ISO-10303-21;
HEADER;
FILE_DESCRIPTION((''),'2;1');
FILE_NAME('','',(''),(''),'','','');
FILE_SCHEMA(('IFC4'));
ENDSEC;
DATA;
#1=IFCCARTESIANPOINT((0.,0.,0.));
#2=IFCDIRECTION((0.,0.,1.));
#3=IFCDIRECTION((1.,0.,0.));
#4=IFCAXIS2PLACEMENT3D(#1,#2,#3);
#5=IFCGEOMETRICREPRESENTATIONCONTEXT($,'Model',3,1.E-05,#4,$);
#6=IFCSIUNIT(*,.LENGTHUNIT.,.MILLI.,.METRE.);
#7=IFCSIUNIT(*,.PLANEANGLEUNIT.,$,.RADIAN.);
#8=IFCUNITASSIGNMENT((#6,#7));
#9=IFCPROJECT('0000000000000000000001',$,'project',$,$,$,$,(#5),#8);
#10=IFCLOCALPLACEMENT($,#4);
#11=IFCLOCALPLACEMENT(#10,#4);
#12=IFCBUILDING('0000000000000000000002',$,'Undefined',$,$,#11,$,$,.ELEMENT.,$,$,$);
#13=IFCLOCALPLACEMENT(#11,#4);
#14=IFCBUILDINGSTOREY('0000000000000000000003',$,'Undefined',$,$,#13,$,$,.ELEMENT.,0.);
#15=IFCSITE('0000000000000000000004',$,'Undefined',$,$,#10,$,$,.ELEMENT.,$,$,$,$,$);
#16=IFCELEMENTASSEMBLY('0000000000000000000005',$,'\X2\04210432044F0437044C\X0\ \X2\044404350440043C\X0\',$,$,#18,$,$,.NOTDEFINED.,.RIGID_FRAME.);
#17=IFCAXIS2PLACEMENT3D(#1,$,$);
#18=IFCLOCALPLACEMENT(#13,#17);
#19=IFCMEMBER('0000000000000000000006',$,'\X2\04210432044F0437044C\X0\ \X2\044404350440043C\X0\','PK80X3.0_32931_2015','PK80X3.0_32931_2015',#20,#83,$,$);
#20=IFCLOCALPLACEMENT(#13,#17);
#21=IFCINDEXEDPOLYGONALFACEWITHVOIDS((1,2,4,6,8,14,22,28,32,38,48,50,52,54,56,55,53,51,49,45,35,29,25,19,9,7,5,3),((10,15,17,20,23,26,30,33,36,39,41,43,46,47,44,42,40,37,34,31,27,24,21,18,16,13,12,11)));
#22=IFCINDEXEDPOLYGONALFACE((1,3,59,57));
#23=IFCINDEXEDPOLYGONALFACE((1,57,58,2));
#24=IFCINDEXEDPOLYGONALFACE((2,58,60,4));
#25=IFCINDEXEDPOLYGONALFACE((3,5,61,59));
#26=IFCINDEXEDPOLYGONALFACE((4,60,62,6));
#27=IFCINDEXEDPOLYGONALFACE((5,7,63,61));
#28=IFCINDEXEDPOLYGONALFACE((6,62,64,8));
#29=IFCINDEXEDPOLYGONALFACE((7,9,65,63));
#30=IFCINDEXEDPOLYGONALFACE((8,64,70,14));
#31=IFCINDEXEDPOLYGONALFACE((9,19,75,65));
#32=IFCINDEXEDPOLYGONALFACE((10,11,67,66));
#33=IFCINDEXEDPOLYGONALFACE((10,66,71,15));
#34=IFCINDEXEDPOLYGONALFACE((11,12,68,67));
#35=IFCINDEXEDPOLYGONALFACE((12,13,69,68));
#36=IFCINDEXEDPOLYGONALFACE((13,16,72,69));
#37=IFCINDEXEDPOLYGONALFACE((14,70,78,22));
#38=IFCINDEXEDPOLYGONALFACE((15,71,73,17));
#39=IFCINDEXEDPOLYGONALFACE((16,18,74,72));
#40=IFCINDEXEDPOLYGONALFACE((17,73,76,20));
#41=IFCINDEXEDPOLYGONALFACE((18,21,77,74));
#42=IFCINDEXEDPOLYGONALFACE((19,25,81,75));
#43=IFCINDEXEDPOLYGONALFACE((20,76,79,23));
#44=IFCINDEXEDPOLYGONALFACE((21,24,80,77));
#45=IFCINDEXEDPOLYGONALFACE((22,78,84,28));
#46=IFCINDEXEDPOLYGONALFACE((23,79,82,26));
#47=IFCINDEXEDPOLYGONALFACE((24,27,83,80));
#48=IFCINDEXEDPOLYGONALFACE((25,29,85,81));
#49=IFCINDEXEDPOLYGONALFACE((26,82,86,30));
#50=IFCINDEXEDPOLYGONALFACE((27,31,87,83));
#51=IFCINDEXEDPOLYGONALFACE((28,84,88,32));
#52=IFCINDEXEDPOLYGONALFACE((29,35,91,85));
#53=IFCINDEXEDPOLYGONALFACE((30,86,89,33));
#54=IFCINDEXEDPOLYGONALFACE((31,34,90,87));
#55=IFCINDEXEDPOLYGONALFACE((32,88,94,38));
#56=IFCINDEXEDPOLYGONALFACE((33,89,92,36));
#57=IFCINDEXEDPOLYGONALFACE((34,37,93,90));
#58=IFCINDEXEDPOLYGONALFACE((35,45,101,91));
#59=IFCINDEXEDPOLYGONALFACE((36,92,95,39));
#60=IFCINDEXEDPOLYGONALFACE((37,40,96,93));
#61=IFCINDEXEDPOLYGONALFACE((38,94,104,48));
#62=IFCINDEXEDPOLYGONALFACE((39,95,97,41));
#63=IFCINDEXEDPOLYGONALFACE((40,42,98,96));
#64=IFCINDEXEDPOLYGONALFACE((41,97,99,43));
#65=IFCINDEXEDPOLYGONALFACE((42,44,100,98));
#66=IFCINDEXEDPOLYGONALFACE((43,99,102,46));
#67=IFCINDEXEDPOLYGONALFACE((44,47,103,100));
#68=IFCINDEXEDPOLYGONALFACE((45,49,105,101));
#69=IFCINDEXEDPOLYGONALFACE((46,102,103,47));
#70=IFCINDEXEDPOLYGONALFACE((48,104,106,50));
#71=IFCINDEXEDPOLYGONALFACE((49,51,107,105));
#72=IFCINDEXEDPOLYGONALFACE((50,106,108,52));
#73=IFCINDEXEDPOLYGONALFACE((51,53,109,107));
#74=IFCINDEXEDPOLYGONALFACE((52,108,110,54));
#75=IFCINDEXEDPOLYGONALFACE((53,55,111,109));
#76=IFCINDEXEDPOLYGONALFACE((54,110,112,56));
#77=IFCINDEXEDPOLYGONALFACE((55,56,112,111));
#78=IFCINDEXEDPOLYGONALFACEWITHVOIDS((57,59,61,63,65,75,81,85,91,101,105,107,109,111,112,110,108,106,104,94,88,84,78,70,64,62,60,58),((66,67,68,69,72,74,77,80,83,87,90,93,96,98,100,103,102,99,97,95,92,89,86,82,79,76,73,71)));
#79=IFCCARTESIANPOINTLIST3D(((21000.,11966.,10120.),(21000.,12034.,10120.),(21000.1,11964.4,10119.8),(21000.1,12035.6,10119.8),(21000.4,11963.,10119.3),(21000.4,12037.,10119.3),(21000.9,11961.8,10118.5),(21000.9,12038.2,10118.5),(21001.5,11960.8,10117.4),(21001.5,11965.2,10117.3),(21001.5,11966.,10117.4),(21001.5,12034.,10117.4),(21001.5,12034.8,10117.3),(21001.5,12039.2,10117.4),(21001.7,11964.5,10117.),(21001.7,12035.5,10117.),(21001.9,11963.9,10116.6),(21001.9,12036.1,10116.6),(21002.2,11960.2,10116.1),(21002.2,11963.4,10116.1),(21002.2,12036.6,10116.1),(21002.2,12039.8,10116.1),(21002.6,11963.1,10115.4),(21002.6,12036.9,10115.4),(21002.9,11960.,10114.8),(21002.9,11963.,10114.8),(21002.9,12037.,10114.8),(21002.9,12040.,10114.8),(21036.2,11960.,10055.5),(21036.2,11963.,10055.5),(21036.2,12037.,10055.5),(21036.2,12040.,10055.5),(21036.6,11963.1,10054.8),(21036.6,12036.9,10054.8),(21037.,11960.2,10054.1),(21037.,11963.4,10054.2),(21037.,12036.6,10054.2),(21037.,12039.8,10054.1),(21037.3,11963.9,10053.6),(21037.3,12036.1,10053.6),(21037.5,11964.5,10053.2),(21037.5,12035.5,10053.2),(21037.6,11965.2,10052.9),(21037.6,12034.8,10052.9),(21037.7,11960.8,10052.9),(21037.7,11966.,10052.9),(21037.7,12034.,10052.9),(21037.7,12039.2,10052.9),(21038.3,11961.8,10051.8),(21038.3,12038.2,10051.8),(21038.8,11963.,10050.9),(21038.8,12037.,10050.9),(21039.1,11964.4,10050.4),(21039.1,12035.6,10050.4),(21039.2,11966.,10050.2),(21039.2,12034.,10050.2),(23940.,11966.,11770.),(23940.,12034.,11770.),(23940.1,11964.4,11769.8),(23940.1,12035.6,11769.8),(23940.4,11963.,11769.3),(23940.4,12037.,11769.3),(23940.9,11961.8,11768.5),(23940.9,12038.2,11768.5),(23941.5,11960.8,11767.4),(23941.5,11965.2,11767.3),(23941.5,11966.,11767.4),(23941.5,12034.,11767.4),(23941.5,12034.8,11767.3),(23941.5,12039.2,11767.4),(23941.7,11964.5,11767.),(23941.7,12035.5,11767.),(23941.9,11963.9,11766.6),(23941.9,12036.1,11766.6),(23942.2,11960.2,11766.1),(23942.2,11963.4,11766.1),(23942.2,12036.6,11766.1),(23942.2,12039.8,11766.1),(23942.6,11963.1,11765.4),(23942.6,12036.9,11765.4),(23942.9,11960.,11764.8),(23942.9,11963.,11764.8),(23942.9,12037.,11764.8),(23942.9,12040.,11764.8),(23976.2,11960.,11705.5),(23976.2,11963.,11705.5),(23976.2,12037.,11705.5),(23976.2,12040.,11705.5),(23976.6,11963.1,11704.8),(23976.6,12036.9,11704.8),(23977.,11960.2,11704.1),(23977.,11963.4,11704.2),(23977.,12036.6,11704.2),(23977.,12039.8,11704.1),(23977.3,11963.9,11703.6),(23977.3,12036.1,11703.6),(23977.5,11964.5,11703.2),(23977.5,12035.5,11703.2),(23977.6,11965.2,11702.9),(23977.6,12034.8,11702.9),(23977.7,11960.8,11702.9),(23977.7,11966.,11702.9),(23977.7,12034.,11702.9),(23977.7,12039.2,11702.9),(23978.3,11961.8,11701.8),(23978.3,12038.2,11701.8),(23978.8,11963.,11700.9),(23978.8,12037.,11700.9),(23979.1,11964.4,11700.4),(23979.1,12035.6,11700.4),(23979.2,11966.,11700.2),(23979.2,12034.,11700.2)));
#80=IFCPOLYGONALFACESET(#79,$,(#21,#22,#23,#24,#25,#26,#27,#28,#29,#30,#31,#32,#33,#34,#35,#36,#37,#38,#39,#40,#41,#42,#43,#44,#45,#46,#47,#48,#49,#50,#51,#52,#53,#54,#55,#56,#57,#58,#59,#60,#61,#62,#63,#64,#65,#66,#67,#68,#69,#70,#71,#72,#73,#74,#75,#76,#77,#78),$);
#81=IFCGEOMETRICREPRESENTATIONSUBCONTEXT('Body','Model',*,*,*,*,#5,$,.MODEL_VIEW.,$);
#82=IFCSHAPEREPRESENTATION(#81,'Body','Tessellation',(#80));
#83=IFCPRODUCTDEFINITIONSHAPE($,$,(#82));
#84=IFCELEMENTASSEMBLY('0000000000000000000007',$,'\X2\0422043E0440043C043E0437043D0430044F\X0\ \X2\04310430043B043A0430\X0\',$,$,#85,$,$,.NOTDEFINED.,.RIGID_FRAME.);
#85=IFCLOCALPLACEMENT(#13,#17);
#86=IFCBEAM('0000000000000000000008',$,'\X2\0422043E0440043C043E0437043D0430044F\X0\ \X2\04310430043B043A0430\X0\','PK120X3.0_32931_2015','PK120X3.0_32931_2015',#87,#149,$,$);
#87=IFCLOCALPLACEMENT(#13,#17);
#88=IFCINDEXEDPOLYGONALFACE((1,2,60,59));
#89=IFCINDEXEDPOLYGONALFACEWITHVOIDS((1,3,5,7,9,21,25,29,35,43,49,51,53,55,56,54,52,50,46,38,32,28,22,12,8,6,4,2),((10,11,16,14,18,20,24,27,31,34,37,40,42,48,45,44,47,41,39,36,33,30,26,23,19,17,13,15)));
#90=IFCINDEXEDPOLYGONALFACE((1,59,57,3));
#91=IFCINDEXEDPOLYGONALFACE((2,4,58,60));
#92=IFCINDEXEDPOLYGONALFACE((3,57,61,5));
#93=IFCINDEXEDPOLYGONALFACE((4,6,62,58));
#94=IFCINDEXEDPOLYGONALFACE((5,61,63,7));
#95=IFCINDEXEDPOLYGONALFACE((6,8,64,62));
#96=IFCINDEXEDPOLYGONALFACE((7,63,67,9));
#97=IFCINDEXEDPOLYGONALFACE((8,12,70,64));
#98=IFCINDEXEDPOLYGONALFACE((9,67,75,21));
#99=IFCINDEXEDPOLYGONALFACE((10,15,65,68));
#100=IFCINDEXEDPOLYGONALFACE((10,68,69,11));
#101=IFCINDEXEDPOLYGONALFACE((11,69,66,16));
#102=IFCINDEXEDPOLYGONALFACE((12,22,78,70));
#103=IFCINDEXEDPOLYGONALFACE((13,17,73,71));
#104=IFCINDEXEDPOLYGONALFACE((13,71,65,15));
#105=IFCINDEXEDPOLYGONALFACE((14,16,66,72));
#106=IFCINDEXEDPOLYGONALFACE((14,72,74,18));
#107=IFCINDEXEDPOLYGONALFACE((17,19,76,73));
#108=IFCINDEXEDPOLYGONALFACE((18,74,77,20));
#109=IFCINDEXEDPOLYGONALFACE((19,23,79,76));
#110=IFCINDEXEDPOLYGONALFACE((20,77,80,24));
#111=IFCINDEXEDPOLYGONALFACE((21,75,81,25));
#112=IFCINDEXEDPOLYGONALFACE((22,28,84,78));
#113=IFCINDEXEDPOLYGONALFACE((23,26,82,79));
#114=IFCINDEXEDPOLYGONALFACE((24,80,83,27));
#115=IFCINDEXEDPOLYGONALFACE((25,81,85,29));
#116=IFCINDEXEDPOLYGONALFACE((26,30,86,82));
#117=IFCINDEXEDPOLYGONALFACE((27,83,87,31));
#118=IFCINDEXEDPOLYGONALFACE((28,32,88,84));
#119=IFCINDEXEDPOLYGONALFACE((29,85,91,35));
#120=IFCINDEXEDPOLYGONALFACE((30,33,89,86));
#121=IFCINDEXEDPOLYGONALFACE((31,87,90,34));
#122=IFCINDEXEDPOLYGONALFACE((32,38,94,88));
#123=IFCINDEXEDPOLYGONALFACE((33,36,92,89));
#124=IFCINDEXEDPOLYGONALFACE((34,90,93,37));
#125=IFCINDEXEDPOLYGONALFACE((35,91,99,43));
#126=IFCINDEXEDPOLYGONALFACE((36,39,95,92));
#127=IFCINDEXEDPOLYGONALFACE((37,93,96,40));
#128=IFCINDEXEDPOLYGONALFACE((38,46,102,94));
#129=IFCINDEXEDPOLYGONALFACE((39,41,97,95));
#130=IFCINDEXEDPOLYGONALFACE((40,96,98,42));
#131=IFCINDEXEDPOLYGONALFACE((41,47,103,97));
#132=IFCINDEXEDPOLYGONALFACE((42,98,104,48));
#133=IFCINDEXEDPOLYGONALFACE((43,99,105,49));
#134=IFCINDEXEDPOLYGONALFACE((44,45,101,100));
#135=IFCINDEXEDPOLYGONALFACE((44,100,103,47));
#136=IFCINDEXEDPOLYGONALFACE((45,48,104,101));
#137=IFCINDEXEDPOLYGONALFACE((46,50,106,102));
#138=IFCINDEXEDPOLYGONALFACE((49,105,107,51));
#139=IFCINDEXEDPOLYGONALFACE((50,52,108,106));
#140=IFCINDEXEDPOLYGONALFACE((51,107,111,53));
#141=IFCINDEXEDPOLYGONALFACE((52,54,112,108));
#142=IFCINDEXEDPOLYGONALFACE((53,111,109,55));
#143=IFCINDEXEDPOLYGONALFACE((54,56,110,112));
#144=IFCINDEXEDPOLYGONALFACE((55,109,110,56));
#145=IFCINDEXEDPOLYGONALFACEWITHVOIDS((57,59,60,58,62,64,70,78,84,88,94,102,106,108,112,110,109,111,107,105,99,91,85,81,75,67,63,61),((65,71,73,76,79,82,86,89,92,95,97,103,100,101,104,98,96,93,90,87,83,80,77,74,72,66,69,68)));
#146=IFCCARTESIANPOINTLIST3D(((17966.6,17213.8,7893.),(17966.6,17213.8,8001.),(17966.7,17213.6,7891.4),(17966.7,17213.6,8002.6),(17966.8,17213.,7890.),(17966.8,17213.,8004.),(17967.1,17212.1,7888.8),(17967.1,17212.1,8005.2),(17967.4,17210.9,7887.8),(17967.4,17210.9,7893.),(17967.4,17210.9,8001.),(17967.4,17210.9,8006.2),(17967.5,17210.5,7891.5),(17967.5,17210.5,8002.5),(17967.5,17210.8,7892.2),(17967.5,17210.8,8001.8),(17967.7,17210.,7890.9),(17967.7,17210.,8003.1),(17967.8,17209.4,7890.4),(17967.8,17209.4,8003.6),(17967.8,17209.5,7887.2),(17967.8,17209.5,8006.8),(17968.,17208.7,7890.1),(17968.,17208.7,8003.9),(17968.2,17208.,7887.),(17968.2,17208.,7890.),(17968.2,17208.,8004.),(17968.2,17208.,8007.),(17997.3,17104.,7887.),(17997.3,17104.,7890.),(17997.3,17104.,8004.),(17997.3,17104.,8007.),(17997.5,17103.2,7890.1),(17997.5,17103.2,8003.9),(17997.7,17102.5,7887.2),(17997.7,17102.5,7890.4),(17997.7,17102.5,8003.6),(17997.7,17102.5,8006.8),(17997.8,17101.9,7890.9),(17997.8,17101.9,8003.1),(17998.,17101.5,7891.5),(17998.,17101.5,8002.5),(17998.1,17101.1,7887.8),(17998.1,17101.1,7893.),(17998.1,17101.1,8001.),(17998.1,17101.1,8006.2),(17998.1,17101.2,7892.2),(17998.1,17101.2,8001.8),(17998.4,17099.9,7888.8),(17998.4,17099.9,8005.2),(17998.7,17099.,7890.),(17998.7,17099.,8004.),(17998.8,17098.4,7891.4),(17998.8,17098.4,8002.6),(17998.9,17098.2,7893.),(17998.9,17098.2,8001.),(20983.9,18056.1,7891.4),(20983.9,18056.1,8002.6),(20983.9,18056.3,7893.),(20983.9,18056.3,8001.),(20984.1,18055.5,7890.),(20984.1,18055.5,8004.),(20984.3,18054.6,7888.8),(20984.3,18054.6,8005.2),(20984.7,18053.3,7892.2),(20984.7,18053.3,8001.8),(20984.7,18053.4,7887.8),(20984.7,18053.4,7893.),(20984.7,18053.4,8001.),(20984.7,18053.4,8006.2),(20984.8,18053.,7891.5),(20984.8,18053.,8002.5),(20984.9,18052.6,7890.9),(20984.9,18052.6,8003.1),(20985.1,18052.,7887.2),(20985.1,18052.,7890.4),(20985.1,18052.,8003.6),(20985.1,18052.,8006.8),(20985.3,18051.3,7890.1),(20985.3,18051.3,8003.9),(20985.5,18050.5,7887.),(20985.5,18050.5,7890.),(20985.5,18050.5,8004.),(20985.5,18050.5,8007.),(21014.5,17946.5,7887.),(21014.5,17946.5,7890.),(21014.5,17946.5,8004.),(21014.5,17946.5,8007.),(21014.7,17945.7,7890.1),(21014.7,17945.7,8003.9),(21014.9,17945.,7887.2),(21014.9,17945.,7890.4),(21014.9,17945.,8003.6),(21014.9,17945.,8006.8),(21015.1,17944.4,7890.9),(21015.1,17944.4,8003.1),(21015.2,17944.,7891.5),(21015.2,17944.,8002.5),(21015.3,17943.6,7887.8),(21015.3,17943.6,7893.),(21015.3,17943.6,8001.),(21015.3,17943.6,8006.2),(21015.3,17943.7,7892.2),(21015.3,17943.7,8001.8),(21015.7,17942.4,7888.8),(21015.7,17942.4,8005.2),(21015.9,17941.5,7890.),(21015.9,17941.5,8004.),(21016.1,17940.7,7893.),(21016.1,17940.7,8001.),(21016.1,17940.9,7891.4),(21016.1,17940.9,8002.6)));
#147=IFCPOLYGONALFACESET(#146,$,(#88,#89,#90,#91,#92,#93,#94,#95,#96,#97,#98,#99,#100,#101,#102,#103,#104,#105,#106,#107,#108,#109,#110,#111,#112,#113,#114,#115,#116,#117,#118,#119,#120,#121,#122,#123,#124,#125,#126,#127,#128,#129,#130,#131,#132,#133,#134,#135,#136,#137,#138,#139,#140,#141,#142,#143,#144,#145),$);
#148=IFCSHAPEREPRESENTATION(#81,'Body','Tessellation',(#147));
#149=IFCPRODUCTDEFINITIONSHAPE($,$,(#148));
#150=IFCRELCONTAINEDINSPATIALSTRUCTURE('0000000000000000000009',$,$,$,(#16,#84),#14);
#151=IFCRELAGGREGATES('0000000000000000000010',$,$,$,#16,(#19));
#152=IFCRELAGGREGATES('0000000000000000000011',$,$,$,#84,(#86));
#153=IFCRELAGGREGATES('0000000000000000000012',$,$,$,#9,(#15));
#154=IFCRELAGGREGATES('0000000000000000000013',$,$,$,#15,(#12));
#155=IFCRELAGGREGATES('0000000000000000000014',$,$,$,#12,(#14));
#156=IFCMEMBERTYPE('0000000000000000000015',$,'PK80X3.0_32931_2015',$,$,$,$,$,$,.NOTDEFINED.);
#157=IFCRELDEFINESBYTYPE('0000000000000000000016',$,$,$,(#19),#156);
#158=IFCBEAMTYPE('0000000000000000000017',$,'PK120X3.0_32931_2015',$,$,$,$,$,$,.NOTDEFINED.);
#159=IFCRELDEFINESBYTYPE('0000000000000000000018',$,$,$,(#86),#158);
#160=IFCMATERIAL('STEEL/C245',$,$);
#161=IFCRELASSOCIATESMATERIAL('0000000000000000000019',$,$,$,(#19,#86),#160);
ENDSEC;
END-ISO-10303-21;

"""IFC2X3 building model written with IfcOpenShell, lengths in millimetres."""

from ifc_helpers import new_model, si_unit, frame, origin_with_axes, origin_2d_with_axis, place, context, subcontext, project, spatial, hollow_rectangle, extrude, material, type_object, element, aggregate, save


model = new_model("IFC2X3")

# Units and contexts
model_context = context("Model", 3, precision=1e-05, world=origin_with_axes())
body_context = subcontext(model_context, "Body", "Model", "MODEL_VIEW")
ifc_project = project(units=[si_unit("LENGTHUNIT", "METRE", prefix="MILLI"), si_unit("PLANEANGLEUNIT", "RADIAN")], contexts=[model_context])

# Site, building, storey
site_placement = place(None, origin_with_axes())
site = spatial("IfcSite", under=ifc_project, at=site_placement, Name="Undefined", CompositionType="ELEMENT")
building_placement = place(site_placement, origin_with_axes())
building = spatial("IfcBuilding", under=site, at=building_placement, Name="Undefined", CompositionType="ELEMENT")
storey_placement = place(building_placement, origin_with_axes())
storey = spatial("IfcBuildingStorey", under=building, at=storey_placement, Name="Undefined", CompositionType="ELEMENT", Elevation=0.0)

# Shared definitions
ifc_material_1 = material(Name="STEEL/C245")

# Element assembly, member
assembly_1_placement = place(storey_placement, origin_with_axes())
assembly_1 = element("IfcElementAssembly", 1, at=assembly_1_placement, inside=storey, Name="Связь ферм", AssemblyPlace="NOTDEFINED", PredefinedType="RIGID_FRAME")
member_type_1 = type_object("IfcMemberType", Name="PK80X3.0_32931_2015", PredefinedType="NOTDEFINED")
member_1_placement = place(assembly_1_placement, frame((21019.6, 12000.0, 10085.1), z_axis=(-0.489416, 0.0, 0.87205), x_axis=(0.87205, 0.0, 0.489416)))
member_1 = element("IfcMember", 2, at=member_1_placement, type_object=member_type_1, material=ifc_material_1, Name="Связь ферм", Description="PK80X3.0_32931_2015", ObjectType="PK80X3.0_32931_2015", context=body_context, shape_type="SweptSolid", body=[
    extrude(hollow_rectangle(XDim=80.0, YDim=80.0, WallThickness=3.0, InnerFilletRadius=3.0, OuterFilletRadius=6.0, at=origin_2d_with_axis()), frame((3371.4, 0.0, 0.0), z_axis=(-1.0, 0.0, 0.0), x_axis=(0.0, -1.0, 0.0)), (0.0, 0.0, 1.0), 3371.4),
])
aggregate(assembly_1, [member_1])

# Element assembly, beam
assembly_2_placement = place(storey_placement, origin_with_axes())
assembly_2 = element("IfcElementAssembly", 3, at=assembly_2_placement, inside=storey, Name="Тормозная балка", AssemblyPlace="NOTDEFINED", PredefinedType="RIGID_FRAME")
beam_type_1 = type_object("IfcBeamType", Name="PK120X3.0_32931_2015", PredefinedType="NOTDEFINED")
beam_1_placement = place(assembly_2_placement, frame((17982.8, 17156.0, 7947.0), z_axis=(0.0, 0.0, -1.0), x_axis=(0.963154, 0.26895, 0.0)))
beam_1 = element("IfcBeam", 4, at=beam_1_placement, type_object=beam_type_1, material=ifc_material_1, Name="Тормозная балка", Description="PK120X3.0_32931_2015", ObjectType="PK120X3.0_32931_2015", context=body_context, shape_type="SweptSolid", body=[
    extrude(hollow_rectangle(XDim=120.0, YDim=120.0, WallThickness=3.0, InnerFilletRadius=3.0, OuterFilletRadius=6.0, at=origin_2d_with_axis()), frame((3132.7, 0.0, 0.0), z_axis=(-1.0, 0.0, 0.0), x_axis=(0.0, -1.0, 0.0)), (0.0, 0.0, 1.0), 3132.7),
])
aggregate(assembly_2, [beam_1])

save(model, "model.ifc")
